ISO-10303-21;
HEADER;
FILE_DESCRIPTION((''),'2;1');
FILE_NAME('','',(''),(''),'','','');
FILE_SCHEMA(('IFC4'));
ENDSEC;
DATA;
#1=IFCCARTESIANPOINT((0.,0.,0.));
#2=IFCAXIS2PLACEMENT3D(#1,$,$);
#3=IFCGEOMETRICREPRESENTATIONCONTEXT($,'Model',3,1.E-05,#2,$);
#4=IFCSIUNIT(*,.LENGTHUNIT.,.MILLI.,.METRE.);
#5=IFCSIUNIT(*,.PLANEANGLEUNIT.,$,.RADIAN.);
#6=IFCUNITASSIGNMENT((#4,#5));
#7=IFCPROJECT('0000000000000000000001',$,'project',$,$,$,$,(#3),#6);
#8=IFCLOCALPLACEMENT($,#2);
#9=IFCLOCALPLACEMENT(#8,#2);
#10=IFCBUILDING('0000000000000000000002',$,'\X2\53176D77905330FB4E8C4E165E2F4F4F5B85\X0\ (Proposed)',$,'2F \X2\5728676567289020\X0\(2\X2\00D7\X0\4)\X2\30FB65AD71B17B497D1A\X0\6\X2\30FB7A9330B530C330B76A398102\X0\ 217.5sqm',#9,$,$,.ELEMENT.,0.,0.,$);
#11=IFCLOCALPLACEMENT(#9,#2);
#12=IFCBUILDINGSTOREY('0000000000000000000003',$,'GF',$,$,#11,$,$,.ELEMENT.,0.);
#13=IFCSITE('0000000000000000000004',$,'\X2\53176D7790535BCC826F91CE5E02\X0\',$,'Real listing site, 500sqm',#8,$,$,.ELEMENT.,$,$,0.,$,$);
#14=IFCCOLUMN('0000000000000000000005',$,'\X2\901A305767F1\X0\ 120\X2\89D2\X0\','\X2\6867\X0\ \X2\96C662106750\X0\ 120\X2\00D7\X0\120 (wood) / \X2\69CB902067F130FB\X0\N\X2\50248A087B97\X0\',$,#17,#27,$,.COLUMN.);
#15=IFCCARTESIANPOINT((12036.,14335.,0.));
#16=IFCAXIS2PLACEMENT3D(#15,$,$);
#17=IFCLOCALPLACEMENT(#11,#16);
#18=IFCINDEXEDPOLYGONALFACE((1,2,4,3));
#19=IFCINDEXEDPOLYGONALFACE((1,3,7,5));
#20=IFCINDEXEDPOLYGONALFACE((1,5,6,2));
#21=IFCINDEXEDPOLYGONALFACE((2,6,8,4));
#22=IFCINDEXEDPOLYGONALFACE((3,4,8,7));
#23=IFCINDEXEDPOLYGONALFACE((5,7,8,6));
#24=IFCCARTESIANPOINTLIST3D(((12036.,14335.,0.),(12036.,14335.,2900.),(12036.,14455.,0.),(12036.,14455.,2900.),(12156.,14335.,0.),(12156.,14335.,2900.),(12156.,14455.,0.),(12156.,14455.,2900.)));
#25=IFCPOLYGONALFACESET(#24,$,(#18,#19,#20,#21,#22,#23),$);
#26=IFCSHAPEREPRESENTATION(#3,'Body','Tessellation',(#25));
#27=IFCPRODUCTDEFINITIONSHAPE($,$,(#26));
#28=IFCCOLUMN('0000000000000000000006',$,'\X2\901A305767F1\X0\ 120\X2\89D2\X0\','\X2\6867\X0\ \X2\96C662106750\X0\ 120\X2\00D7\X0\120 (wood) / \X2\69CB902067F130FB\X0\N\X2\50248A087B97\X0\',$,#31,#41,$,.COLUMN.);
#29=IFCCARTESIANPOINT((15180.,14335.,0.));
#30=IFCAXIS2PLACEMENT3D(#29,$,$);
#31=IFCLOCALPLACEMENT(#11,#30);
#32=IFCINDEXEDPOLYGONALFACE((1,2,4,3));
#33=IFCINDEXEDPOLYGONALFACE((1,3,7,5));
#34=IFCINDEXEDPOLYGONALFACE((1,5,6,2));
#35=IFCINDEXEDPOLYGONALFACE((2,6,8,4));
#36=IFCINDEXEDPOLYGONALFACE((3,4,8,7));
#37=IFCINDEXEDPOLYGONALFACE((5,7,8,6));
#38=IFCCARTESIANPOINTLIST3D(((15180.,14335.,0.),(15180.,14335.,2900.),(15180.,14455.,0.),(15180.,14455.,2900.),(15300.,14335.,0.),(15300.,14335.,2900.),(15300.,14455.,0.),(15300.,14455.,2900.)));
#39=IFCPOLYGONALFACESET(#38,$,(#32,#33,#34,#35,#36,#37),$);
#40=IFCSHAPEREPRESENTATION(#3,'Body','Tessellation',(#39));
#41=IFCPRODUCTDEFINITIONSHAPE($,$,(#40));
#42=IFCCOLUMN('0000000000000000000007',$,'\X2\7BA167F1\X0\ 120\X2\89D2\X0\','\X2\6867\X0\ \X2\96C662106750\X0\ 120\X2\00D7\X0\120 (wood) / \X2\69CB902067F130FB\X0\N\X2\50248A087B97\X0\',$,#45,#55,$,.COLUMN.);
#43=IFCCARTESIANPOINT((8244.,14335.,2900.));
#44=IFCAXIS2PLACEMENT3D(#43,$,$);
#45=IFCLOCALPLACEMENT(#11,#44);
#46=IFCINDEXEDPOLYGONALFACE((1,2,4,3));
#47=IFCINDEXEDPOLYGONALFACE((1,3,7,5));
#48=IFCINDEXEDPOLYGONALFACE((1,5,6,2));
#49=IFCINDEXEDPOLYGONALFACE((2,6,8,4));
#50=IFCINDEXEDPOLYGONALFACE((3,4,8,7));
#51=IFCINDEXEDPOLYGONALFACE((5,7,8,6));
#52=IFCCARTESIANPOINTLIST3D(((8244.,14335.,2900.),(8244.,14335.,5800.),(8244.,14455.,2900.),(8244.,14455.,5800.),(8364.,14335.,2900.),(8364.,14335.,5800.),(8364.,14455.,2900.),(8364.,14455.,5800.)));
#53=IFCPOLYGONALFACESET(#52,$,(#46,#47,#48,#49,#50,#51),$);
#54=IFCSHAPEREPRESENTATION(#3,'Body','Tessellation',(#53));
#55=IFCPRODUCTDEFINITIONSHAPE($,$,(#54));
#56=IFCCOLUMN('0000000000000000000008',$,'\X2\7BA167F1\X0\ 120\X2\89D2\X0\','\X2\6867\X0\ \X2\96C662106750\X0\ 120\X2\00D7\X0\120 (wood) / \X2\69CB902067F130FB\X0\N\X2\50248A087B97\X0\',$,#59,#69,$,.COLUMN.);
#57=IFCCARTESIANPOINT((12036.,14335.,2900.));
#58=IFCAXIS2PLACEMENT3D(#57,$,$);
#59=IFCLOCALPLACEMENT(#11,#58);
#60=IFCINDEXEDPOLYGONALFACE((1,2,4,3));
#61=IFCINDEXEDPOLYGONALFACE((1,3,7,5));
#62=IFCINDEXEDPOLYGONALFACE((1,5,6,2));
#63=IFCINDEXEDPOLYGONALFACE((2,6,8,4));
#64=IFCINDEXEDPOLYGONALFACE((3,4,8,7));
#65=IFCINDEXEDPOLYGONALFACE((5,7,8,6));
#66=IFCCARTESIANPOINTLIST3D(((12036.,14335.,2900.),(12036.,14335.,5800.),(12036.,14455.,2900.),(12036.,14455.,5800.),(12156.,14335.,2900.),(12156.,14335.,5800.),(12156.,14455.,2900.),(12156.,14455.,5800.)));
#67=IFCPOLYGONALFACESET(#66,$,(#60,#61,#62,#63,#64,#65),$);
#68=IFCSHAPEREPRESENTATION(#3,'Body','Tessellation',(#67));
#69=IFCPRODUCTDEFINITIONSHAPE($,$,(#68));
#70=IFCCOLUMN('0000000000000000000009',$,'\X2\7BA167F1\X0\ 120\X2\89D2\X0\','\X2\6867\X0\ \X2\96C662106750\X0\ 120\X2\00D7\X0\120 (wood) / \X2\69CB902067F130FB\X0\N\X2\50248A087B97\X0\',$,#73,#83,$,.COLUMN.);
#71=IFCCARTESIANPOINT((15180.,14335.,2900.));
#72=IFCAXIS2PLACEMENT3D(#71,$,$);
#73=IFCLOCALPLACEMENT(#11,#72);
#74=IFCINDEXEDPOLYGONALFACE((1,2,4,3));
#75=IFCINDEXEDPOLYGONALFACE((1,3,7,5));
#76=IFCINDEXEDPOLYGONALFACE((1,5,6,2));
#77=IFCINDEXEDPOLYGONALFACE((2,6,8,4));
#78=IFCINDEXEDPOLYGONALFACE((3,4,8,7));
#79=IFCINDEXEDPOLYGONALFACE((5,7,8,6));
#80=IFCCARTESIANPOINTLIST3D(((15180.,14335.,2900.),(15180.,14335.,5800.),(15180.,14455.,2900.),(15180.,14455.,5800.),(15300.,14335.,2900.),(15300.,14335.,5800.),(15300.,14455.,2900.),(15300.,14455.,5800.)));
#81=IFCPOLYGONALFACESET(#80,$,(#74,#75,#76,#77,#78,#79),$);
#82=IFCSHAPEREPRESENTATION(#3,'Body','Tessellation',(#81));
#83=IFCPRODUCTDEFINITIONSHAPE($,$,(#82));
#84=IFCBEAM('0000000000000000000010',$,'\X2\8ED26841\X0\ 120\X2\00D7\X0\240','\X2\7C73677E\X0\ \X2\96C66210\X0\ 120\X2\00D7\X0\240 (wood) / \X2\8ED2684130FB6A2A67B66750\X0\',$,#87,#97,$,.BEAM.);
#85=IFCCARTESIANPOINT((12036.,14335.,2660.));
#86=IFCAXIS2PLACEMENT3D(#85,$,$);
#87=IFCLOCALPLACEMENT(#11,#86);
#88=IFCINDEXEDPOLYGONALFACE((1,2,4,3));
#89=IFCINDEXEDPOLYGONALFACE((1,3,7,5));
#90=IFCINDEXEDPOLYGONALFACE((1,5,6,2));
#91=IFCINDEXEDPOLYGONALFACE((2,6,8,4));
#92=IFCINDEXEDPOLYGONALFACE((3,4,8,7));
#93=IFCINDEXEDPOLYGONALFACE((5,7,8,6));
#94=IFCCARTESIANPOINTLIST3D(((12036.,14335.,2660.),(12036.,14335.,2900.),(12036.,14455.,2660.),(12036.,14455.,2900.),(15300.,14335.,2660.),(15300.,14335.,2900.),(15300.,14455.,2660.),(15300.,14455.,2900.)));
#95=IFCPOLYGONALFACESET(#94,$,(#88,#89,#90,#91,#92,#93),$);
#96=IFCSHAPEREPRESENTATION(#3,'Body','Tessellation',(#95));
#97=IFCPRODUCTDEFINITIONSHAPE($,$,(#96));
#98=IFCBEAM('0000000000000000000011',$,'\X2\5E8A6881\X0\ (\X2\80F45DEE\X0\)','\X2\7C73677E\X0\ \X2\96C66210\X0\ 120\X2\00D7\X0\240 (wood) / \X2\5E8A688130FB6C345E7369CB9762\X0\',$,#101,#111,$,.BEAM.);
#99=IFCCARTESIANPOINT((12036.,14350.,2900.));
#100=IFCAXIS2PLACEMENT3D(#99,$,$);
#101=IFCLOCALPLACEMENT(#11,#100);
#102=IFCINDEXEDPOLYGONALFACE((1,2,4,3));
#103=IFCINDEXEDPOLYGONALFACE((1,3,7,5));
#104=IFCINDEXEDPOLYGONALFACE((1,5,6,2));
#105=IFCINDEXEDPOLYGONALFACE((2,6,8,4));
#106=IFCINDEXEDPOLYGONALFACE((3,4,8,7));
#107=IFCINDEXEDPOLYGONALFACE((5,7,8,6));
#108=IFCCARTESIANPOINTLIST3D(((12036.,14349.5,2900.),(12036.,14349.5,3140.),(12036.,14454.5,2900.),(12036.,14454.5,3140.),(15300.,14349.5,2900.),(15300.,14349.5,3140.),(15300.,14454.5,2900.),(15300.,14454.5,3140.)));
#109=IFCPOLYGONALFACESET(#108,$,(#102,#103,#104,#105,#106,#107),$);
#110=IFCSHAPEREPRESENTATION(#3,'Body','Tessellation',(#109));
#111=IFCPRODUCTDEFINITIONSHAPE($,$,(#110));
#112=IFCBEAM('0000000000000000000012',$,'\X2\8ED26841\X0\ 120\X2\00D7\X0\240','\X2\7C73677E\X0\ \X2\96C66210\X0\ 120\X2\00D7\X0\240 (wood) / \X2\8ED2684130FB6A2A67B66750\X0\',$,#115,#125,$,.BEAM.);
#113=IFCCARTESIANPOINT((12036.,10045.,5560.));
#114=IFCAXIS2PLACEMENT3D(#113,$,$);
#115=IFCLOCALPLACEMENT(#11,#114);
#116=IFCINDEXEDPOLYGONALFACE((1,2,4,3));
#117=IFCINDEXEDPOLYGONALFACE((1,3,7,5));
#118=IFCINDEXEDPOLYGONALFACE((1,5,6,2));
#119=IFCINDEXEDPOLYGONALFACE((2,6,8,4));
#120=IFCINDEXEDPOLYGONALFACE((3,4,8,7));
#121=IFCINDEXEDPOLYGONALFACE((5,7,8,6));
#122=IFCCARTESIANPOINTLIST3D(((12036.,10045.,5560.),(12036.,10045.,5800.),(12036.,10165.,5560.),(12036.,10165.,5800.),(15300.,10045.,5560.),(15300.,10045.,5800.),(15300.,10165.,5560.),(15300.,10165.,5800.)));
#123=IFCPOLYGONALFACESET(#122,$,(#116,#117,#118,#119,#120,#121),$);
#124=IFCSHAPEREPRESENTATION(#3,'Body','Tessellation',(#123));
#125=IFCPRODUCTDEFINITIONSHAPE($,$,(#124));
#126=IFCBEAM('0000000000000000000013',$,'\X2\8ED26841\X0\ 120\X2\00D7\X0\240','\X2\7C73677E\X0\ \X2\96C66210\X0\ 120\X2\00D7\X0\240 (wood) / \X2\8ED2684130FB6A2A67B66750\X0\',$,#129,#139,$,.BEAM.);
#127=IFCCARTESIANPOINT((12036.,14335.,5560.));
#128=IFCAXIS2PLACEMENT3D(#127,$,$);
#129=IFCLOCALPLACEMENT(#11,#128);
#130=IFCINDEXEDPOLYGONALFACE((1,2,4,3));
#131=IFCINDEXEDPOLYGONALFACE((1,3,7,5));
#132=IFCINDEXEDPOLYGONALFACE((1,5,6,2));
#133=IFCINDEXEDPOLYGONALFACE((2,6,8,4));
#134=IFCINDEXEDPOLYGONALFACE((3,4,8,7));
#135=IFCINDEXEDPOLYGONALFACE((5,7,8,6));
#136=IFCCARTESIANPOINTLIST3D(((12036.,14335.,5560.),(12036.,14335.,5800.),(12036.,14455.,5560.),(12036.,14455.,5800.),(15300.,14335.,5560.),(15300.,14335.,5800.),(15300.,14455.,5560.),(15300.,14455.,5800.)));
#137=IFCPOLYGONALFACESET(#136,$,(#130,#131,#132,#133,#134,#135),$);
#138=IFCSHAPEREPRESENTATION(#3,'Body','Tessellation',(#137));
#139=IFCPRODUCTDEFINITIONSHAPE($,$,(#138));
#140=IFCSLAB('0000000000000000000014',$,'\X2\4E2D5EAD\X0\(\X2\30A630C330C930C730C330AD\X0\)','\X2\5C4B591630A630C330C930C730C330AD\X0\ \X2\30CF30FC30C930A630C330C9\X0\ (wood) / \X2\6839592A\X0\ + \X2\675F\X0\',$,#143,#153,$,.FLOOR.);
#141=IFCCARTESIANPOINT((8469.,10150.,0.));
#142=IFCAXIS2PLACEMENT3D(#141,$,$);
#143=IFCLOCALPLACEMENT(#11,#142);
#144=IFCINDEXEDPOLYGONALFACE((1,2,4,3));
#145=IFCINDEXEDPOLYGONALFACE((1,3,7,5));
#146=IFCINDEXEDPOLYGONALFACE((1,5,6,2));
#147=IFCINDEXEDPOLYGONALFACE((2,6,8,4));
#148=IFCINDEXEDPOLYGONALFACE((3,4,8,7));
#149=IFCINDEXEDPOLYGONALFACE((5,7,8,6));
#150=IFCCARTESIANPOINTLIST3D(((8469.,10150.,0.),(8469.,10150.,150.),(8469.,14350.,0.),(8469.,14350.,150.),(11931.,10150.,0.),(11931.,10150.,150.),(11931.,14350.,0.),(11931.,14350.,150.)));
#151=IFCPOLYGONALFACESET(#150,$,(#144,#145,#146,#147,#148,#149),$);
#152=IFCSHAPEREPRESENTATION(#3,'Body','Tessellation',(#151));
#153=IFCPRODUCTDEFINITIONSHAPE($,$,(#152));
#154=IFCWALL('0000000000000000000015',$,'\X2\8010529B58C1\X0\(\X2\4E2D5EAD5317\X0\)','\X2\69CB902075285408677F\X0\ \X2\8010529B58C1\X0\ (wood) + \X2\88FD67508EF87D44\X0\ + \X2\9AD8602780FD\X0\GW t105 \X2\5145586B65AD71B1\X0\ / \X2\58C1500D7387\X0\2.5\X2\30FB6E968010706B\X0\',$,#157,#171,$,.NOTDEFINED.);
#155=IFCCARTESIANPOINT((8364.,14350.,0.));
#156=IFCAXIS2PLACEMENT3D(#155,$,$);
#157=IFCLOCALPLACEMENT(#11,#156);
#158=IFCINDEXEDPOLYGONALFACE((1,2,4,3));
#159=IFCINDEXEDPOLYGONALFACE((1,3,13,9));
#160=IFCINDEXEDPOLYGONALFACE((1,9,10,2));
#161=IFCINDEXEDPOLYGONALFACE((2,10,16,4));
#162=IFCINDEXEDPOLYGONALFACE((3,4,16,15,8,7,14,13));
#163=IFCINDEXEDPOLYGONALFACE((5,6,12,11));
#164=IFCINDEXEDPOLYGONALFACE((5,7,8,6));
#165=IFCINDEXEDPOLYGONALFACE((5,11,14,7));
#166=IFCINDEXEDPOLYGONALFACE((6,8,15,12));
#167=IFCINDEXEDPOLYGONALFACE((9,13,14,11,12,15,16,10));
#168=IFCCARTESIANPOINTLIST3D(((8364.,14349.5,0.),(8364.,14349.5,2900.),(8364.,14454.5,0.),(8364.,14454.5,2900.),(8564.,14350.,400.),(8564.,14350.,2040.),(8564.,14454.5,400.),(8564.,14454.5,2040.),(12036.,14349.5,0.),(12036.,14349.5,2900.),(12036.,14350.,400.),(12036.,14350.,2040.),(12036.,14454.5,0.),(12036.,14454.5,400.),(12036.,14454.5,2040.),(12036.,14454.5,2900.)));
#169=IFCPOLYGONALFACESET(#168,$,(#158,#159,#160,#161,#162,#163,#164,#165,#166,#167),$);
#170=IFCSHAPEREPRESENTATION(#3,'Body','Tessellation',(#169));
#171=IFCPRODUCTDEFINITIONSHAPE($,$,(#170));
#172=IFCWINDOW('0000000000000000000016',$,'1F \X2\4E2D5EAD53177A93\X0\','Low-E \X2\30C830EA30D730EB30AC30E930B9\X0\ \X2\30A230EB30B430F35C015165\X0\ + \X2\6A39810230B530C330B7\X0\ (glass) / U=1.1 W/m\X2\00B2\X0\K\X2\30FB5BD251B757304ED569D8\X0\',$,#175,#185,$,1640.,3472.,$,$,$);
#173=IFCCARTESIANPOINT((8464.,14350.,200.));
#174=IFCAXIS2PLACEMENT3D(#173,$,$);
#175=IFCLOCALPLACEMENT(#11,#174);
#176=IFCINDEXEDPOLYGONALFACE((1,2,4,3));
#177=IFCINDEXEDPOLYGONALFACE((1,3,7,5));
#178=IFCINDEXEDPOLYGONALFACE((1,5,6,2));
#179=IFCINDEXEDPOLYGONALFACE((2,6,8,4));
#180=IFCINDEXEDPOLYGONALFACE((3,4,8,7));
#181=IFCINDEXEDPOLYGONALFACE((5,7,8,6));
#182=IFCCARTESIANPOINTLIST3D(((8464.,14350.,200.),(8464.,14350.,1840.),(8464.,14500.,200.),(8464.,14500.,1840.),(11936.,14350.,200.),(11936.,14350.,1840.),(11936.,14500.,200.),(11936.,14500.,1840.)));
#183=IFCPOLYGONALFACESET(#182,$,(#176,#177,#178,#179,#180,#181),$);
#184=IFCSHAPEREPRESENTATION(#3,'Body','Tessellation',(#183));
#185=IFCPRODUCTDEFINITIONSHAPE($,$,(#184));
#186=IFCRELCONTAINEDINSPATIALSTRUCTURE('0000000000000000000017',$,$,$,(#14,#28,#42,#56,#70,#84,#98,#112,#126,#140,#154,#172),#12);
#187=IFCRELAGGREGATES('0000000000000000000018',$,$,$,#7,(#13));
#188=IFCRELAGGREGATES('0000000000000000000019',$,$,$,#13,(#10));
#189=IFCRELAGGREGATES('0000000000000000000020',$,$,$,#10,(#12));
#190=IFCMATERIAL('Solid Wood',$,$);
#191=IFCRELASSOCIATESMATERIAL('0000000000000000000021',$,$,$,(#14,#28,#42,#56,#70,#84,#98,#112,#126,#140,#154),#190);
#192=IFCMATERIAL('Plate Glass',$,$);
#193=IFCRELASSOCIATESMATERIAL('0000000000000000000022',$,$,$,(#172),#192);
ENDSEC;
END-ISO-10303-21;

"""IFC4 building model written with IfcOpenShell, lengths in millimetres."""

from ifc_helpers import new_model, si_unit, frame, frame_2d, origin, place, context, project, spatial, rectangle, extrude, material, element, fill, save


model = new_model("IFC4")

# Units and contexts
model_context = context("Model", 3, precision=1e-05, world=origin())
ifc_project = project(units=[si_unit("LENGTHUNIT", "METRE", prefix="MILLI"), si_unit("PLANEANGLEUNIT", "RADIAN")], contexts=[model_context])

# Site, building, storey
site_placement = place(None, origin())
site = spatial("IfcSite", under=ifc_project, at=site_placement, Name="北海道富良野市", ObjectType="Real listing site, 500sqm", CompositionType="ELEMENT", RefElevation=0.0)
building_placement = place(site_placement, origin())
building = spatial("IfcBuilding", under=site, at=building_placement, Name="北海道・二世帯住宅 (Proposed)", ObjectType="2F 在来木造(2×4)・断熱等級6・窓サッシ樹脂 217.5sqm", CompositionType="ELEMENT", ElevationOfRefHeight=0.0, ElevationOfTerrain=0.0)
storey_placement = place(building_placement, origin())
storey = spatial("IfcBuildingStorey", under=building, at=storey_placement, Name="GF", CompositionType="ELEMENT", Elevation=0.0)

# Columns
ifc_material_1 = material(Name="Solid Wood")
column_1_placement = place(storey_placement, frame((12036.0, 14335.0, 0.0)))
element("IfcColumn", 1, at=column_1_placement, inside=storey, material=ifc_material_1, Name="通し柱 120角", Description="桧 集成材 120×120 (wood) / 構造柱・N値計算", PredefinedType="COLUMN", context=model_context, shape_type="SweptSolid", body=[
    extrude(rectangle(XDim=120.0, YDim=120.0, at=frame_2d((60.0, 60.0))), frame((12036.0, 14335.0, 0.0)), (0.0, 0.0, 1.0), 2900.0),
])
column_2_placement = place(storey_placement, frame((15180.0, 14335.0, 0.0)))
element("IfcColumn", 2, at=column_2_placement, inside=storey, material=ifc_material_1, Name="通し柱 120角", Description="桧 集成材 120×120 (wood) / 構造柱・N値計算", PredefinedType="COLUMN", context=model_context, shape_type="SweptSolid", body=[
    extrude(rectangle(XDim=120.0, YDim=120.0, at=frame_2d((60.0, 60.0))), frame((15180.0, 14335.0, 0.0)), (0.0, 0.0, 1.0), 2900.0),
])
column_3_placement = place(storey_placement, frame((8244.0, 14335.0, 2900.0)))
element("IfcColumn", 3, at=column_3_placement, inside=storey, material=ifc_material_1, Name="管柱 120角", Description="桧 集成材 120×120 (wood) / 構造柱・N値計算", PredefinedType="COLUMN", context=model_context, shape_type="SweptSolid", body=[
    extrude(rectangle(XDim=120.0, YDim=120.0, at=frame_2d((60.0, 60.0))), frame((8244.0, 14335.0, 2900.0)), (0.0, 0.0, 1.0), 2900.0),
])
column_4_placement = place(storey_placement, frame((12036.0, 14335.0, 2900.0)))
element("IfcColumn", 4, at=column_4_placement, inside=storey, material=ifc_material_1, Name="管柱 120角", Description="桧 集成材 120×120 (wood) / 構造柱・N値計算", PredefinedType="COLUMN", context=model_context, shape_type="SweptSolid", body=[
    extrude(rectangle(XDim=120.0, YDim=120.0, at=frame_2d((60.0, 60.0))), frame((12036.0, 14335.0, 2900.0)), (0.0, 0.0, 1.0), 2900.0),
])
column_5_placement = place(storey_placement, frame((15180.0, 14335.0, 2900.0)))
element("IfcColumn", 5, at=column_5_placement, inside=storey, material=ifc_material_1, Name="管柱 120角", Description="桧 集成材 120×120 (wood) / 構造柱・N値計算", PredefinedType="COLUMN", context=model_context, shape_type="SweptSolid", body=[
    extrude(rectangle(XDim=120.0, YDim=120.0, at=frame_2d((60.0, 60.0))), frame((15180.0, 14335.0, 2900.0)), (0.0, 0.0, 1.0), 2900.0),
])

# Beams
beam_1_placement = place(storey_placement, frame((12036.0, 14335.0, 2660.0)))
element("IfcBeam", 6, at=beam_1_placement, inside=storey, material=ifc_material_1, Name="軒桁 120×240", Description="米松 集成 120×240 (wood) / 軒桁・横架材", PredefinedType="BEAM", context=model_context, shape_type="SweptSolid", body=[
    extrude(rectangle(XDim=3264.0, YDim=120.0, at=frame_2d((1632.0, 60.0))), frame((12036.0, 14335.0, 2660.0)), (0.0, 0.0, 1.0), 240.0),
])
beam_2_placement = place(storey_placement, frame((12036.0, 14350.0, 2900.0)))
element("IfcBeam", 7, at=beam_2_placement, inside=storey, material=ifc_material_1, Name="床梁 (胴差)", Description="米松 集成 120×240 (wood) / 床梁・水平構面", PredefinedType="BEAM", context=model_context, shape_type="SweptSolid", body=[
    extrude(rectangle(XDim=3264.0, YDim=105.0, at=frame_2d((1632.0, 52.0))), frame((12036.0, 14350.0, 2900.0)), (0.0, 0.0, 1.0), 240.0),
])
beam_3_placement = place(storey_placement, frame((12036.0, 10045.0, 5560.0)))
element("IfcBeam", 8, at=beam_3_placement, inside=storey, material=ifc_material_1, Name="軒桁 120×240", Description="米松 集成 120×240 (wood) / 軒桁・横架材", PredefinedType="BEAM", context=model_context, shape_type="SweptSolid", body=[
    extrude(rectangle(XDim=3264.0, YDim=120.0, at=frame_2d((1632.0, 60.0))), frame((12036.0, 10045.0, 5560.0)), (0.0, 0.0, 1.0), 240.0),
])
beam_4_placement = place(storey_placement, frame((12036.0, 14335.0, 5560.0)))
element("IfcBeam", 9, at=beam_4_placement, inside=storey, material=ifc_material_1, Name="軒桁 120×240", Description="米松 集成 120×240 (wood) / 軒桁・横架材", PredefinedType="BEAM", context=model_context, shape_type="SweptSolid", body=[
    extrude(rectangle(XDim=3264.0, YDim=120.0, at=frame_2d((1632.0, 60.0))), frame((12036.0, 14335.0, 5560.0)), (0.0, 0.0, 1.0), 240.0),
])

# Slab
slab_placement = place(storey_placement, frame((8469.0, 10150.0, 0.0)))
element("IfcSlab", 10, at=slab_placement, inside=storey, material=ifc_material_1, Name="中庭(ウッドデッキ)", Description="屋外ウッドデッキ ハードウッド (wood) / 根太 + 束", PredefinedType="FLOOR", context=model_context, shape_type="SweptSolid", body=[
    extrude(rectangle(XDim=3462.0, YDim=4200.0, at=frame_2d((1731.0, 2100.0))), frame((8469.0, 10150.0, 0.0)), (0.0, 0.0, 1.0), 150.0),
])

# Wall, opening, window
wall_1_placement = place(storey_placement, frame((8364.0, 14350.0, 0.0)))
wall_1 = element("IfcWall", 11, at=wall_1_placement, inside=storey, material=ifc_material_1, Name="耐力壁(中庭北)", Description="構造用合板 耐力壁 (wood) + 製材軸組 + 高性能GW t105 充填断熱 / 壁倍率2.5・準耐火", PredefinedType="NOTDEFINED", context=model_context, shape_type="SweptSolid", body=[
    extrude(rectangle(XDim=3672.0, YDim=105.0, at=frame_2d((1836.0, 52.0))), frame((8364.0, 14350.0, 0.0)), (0.0, 0.0, 1.0), 2900.0),
])
opening_1_placement = place(storey_placement, frame((8464.0, 14350.0, 200.0)))
opening_1 = element("IfcOpeningElement", 12, at=opening_1_placement, cuts=wall_1, PredefinedType="NOTDEFINED", context=model_context, shape_type="SweptSolid", body=[
    extrude(rectangle(XDim=3472.0, YDim=150.0, at=frame_2d((1736.0, 75.0))), frame((8464.0, 14350.0, 200.0)), (0.0, 0.0, 1.0), 1640.0),
])
ifc_material_2 = material(Name="Plate Glass")
window_1_placement = place(storey_placement, frame((8464.0, 14350.0, 200.0)))
window_1 = element("IfcWindow", 13, at=window_1_placement, inside=storey, material=ifc_material_2, Name="1F 中庭北窓", Description="Low-E トリプルガラス アルゴン封入 + 樹脂サッシ (glass) / U=1.1 W/m²K・寒冷地仕様", OverallHeight=1640.0, OverallWidth=3472.0, context=model_context, shape_type="SweptSolid", body=[
    extrude(rectangle(XDim=3472.0, YDim=150.0, at=frame_2d((1736.0, 75.0))), frame((8464.0, 14350.0, 200.0)), (0.0, 0.0, 1.0), 1640.0),
])
fill(opening_1, window_1)

save(model, "model.ifc")
